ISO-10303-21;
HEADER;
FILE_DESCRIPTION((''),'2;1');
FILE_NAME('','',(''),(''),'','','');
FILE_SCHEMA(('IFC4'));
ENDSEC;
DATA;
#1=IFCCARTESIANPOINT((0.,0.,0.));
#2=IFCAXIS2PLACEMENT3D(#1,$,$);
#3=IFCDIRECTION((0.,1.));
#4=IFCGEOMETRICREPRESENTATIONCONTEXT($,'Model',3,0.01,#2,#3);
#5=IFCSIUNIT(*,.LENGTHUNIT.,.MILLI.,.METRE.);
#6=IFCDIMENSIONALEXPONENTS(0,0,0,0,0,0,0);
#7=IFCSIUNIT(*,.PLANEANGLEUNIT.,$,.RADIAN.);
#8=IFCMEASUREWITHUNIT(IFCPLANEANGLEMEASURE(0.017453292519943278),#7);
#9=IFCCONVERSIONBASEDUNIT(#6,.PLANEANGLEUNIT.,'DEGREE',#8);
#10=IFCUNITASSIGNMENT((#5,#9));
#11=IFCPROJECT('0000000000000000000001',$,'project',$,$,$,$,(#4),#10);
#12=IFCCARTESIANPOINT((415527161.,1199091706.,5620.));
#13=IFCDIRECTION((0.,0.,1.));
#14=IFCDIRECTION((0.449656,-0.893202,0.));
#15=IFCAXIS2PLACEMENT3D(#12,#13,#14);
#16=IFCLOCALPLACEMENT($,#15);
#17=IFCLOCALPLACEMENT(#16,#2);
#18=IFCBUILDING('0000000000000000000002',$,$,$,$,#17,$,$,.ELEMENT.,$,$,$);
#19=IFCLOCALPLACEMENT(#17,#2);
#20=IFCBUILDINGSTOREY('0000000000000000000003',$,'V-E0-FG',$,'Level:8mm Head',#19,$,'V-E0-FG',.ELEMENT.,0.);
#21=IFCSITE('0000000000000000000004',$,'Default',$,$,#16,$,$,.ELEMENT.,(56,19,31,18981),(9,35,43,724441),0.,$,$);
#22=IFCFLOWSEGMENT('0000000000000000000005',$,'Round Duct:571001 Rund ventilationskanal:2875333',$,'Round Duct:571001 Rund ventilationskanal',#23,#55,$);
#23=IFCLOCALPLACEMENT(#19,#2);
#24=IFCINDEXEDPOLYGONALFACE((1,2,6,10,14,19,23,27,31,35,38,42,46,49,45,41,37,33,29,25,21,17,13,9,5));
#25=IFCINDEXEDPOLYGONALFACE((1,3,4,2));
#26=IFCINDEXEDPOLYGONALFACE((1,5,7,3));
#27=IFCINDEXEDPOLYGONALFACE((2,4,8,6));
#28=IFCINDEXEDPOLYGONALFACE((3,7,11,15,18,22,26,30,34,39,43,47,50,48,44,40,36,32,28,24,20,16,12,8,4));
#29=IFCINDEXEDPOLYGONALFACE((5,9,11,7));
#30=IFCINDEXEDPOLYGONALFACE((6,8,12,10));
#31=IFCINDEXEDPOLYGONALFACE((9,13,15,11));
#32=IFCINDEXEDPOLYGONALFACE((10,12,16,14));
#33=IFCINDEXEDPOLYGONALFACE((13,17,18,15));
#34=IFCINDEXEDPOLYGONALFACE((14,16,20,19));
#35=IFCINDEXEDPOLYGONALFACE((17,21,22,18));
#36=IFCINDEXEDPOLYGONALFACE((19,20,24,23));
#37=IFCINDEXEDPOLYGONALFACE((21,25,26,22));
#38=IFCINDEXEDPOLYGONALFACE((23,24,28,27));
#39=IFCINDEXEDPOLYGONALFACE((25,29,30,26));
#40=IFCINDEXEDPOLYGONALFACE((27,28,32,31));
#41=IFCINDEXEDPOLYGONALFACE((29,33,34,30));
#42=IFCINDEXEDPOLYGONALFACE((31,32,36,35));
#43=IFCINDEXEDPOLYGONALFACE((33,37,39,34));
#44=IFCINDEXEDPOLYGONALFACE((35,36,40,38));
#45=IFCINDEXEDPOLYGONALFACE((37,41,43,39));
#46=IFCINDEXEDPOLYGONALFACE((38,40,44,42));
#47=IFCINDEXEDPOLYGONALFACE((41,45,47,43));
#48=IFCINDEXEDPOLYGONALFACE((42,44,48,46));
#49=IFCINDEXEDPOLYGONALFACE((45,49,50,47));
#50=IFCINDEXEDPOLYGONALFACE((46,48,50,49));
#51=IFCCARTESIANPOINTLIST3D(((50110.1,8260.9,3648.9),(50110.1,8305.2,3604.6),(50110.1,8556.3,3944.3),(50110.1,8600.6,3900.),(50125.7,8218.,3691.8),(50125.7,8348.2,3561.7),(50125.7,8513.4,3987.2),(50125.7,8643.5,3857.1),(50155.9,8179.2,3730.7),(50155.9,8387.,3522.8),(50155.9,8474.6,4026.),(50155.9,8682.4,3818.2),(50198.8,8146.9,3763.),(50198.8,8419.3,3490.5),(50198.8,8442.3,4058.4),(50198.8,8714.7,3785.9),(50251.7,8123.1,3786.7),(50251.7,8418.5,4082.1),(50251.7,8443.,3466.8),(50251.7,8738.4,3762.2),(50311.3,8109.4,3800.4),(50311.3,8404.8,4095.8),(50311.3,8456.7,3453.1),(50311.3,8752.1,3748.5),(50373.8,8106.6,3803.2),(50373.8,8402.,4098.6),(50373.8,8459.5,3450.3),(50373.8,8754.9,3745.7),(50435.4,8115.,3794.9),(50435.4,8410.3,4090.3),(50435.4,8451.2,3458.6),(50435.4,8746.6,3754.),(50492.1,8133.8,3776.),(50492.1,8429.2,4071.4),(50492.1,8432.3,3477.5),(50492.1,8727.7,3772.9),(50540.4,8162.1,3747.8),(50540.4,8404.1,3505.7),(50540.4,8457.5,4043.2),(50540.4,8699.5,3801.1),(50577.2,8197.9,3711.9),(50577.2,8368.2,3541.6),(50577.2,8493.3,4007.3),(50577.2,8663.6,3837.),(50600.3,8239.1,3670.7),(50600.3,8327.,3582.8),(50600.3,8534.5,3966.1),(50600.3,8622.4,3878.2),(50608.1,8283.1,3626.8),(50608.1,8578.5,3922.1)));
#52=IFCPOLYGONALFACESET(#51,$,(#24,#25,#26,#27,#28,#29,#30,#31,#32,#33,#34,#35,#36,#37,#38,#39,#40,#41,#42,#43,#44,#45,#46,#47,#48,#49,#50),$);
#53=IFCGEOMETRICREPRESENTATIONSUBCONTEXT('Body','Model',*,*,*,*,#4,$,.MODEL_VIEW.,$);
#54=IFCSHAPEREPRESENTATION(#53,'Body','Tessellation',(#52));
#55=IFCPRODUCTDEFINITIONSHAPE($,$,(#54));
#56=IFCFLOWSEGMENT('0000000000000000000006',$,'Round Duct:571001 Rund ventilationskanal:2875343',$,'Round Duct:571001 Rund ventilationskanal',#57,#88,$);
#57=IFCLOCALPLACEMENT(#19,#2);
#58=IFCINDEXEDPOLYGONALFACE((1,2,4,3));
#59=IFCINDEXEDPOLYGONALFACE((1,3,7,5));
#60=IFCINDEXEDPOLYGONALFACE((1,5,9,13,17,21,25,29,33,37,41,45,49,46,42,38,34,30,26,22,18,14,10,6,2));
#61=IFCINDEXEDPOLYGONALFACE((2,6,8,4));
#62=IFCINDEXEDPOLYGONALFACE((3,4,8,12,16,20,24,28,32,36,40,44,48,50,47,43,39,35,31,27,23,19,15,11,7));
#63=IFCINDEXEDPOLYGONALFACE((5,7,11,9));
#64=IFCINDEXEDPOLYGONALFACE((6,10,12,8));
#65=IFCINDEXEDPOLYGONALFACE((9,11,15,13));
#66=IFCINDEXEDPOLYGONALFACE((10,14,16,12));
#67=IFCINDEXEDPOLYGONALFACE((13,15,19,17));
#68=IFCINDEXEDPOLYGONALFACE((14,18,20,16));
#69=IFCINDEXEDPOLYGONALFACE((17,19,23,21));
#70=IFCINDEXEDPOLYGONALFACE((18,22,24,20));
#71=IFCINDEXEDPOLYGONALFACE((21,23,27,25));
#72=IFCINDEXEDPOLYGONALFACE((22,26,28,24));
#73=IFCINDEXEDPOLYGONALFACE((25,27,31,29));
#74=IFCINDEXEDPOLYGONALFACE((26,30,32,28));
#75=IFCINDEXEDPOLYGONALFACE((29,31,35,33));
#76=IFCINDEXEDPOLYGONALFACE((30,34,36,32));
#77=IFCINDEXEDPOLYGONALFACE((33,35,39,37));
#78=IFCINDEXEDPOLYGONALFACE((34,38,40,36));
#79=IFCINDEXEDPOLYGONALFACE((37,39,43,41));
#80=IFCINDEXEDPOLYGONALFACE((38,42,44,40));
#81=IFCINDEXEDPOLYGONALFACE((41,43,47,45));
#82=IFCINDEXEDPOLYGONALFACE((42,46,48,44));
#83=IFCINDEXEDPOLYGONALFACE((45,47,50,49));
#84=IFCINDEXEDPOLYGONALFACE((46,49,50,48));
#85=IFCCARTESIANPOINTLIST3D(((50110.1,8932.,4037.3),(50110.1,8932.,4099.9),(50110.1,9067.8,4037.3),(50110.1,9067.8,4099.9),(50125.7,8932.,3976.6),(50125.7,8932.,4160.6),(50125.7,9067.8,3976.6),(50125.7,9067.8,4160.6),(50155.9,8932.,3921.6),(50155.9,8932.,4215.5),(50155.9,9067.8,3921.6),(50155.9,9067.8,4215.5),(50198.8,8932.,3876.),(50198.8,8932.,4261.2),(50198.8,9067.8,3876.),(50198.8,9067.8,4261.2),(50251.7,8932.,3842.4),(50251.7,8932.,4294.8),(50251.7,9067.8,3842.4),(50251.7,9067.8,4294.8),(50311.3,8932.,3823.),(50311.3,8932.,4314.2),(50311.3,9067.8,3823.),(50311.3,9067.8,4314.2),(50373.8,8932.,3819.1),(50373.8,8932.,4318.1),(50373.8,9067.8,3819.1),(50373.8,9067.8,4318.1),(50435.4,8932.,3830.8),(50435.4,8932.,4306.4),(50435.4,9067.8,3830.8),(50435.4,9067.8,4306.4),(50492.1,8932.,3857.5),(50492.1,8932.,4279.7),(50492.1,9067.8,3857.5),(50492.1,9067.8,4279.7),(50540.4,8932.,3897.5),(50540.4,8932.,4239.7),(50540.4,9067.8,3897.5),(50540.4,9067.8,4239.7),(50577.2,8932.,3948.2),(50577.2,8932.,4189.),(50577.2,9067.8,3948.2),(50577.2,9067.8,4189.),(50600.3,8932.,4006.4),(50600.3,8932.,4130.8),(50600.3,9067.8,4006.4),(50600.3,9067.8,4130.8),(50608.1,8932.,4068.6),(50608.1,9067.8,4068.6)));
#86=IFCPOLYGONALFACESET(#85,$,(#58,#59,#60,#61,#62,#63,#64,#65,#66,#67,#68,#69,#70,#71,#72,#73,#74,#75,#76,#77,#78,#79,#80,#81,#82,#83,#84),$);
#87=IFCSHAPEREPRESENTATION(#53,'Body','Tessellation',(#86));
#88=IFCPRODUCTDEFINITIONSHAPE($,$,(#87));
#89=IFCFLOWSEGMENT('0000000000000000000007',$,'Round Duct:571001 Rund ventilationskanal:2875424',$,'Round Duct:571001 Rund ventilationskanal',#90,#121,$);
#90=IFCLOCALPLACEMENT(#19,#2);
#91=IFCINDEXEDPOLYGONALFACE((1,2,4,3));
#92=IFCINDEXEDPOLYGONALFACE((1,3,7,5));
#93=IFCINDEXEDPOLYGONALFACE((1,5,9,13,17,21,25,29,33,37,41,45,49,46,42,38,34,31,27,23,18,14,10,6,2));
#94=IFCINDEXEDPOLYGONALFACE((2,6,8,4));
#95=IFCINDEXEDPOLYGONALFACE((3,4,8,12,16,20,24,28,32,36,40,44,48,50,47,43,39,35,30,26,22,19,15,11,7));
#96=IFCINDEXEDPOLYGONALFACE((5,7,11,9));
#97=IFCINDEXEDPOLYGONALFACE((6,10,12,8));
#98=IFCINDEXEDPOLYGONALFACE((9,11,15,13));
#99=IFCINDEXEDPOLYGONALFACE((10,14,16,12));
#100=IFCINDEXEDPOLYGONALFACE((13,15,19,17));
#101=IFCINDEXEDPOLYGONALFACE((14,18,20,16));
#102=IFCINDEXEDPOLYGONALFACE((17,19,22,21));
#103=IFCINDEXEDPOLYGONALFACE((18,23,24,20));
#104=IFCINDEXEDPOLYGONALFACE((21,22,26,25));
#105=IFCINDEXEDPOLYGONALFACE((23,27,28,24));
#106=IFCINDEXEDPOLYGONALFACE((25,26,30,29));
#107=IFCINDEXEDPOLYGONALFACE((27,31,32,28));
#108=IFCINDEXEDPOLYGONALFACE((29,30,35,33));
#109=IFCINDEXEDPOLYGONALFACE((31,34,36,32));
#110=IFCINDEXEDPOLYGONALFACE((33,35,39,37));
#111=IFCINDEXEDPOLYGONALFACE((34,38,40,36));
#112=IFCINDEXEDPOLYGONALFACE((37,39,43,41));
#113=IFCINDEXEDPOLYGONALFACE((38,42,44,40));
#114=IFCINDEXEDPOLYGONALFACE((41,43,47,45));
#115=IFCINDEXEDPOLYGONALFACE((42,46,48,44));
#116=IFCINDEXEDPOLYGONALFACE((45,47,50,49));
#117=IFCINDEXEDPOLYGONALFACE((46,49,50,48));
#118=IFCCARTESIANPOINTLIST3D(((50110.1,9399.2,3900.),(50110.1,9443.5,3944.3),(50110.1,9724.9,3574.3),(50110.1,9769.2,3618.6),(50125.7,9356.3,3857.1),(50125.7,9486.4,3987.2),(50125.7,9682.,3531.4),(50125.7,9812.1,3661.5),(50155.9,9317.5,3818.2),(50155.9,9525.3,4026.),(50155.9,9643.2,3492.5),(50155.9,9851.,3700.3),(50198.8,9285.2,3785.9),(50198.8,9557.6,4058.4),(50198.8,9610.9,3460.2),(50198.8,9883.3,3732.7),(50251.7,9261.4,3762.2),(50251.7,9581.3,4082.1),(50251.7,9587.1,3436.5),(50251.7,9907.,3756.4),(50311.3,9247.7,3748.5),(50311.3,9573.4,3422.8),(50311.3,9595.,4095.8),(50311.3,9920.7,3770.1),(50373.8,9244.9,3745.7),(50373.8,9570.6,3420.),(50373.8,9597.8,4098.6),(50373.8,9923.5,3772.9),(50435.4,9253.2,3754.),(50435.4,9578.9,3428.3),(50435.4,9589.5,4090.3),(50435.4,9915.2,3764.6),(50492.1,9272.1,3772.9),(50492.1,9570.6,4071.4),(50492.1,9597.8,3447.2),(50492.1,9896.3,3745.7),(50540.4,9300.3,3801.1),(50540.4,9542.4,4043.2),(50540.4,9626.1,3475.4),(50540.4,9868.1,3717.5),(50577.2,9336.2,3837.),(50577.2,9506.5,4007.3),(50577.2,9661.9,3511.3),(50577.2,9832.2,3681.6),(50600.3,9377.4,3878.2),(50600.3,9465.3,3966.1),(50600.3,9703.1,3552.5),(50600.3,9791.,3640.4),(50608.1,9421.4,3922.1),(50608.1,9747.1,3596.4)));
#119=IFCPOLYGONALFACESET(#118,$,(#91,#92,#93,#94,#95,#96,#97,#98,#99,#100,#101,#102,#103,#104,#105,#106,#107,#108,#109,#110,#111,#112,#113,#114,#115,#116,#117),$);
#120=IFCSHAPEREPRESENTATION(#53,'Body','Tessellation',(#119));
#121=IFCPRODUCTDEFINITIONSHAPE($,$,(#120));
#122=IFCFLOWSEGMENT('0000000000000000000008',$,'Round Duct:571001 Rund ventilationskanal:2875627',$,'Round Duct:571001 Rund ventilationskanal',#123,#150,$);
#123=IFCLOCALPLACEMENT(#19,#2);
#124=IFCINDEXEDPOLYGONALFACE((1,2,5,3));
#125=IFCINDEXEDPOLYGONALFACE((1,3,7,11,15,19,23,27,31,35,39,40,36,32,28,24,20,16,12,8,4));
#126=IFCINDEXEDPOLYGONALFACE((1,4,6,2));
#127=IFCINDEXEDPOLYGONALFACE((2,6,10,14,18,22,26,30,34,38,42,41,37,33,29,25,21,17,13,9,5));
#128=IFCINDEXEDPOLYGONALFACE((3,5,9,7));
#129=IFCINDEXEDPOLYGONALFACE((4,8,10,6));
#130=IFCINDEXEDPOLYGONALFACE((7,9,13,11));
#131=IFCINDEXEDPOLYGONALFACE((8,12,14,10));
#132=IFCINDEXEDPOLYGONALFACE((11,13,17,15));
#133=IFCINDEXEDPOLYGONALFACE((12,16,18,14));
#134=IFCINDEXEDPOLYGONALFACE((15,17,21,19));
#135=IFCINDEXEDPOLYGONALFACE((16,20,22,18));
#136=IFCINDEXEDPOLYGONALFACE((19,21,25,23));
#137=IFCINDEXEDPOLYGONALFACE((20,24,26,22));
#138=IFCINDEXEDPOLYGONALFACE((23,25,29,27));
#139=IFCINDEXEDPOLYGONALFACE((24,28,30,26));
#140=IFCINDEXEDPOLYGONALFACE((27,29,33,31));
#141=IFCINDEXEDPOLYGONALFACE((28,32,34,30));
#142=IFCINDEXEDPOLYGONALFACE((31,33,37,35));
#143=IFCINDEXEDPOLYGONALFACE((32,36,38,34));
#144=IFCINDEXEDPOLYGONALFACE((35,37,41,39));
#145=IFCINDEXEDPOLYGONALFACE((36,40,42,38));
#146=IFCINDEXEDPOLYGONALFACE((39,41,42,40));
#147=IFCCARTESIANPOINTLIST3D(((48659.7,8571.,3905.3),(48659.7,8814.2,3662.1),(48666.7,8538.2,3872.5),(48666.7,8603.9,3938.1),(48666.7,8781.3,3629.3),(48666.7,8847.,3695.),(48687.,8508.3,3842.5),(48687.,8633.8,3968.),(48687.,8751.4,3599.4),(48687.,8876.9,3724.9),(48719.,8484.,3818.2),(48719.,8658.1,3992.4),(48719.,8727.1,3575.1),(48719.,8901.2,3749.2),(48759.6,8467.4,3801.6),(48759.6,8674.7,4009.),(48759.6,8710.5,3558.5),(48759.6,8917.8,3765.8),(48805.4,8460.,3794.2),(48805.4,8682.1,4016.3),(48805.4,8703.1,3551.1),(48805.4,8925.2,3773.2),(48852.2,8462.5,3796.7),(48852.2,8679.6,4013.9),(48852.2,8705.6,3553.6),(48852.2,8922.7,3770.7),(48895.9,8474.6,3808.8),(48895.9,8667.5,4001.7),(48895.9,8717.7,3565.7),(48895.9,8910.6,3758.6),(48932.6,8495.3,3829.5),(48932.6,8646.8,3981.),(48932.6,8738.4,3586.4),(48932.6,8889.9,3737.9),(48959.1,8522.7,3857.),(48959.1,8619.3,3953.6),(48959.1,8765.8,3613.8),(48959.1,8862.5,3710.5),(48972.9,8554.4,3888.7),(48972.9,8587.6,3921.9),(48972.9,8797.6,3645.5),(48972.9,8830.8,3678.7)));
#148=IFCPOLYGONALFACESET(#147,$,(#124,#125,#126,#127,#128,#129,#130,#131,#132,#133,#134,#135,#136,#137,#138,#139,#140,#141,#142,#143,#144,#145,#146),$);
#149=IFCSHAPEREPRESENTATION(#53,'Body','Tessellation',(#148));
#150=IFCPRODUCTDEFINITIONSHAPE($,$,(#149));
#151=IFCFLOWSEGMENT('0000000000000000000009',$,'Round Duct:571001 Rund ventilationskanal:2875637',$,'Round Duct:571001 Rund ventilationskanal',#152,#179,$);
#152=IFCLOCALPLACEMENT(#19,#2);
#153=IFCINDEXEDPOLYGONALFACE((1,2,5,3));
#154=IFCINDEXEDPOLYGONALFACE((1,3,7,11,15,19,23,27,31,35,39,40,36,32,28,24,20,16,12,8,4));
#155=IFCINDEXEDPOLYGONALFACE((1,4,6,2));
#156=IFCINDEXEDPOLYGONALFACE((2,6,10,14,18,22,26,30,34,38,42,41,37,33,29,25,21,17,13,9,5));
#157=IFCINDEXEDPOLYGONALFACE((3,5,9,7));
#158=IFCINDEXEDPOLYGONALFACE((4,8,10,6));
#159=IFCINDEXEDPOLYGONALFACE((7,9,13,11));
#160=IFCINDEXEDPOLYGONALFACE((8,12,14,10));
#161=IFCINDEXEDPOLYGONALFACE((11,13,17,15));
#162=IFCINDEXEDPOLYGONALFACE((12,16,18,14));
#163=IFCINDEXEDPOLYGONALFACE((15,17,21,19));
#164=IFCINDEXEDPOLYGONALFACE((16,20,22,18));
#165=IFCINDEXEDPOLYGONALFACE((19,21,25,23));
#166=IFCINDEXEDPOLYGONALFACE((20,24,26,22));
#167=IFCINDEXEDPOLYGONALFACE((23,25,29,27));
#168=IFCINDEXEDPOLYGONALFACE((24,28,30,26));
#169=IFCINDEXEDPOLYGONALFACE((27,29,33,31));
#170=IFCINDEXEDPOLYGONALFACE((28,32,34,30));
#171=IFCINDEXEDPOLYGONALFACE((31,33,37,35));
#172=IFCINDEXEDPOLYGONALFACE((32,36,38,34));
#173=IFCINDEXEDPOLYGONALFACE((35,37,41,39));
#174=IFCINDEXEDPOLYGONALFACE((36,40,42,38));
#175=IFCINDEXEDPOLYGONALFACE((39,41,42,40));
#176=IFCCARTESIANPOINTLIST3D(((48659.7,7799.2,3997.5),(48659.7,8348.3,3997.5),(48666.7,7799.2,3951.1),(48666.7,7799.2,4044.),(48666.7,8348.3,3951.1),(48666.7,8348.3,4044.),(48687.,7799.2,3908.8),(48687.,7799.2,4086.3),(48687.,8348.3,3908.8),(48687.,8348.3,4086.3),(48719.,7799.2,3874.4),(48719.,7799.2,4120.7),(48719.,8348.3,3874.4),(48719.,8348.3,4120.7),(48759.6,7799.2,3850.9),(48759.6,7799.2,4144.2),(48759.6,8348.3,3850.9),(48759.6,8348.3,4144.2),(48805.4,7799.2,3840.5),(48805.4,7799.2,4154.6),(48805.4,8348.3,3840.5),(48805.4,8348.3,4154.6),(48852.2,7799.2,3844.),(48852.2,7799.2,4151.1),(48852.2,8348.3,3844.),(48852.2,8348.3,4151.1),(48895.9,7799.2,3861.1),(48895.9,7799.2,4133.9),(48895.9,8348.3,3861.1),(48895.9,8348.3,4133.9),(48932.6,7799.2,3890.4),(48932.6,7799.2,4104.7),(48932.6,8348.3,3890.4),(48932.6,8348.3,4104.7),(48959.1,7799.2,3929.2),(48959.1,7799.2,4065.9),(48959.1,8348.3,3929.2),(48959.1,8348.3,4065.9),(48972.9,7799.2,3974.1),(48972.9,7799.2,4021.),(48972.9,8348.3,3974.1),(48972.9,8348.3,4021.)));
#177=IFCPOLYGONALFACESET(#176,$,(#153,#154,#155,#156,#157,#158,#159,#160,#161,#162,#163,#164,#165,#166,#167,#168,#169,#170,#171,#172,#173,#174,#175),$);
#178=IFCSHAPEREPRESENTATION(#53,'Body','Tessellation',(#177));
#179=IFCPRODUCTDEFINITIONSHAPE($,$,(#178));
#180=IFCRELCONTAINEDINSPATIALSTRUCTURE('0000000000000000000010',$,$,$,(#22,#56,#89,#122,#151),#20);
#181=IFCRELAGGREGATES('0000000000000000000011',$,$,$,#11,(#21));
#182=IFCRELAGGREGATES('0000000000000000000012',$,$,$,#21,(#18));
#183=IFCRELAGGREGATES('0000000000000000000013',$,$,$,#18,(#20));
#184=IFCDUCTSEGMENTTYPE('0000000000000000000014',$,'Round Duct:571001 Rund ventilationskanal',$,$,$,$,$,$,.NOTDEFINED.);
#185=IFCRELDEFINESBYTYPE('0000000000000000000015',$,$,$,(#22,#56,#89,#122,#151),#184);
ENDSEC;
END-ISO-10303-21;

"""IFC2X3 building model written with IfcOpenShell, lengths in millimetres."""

from ifc_helpers import new_model, entity, si_unit, converted_unit, direction, frame, frame_2d, origin, origin_2d_with_axis, place, context, subcontext, project, spatial, circle, extrude, type_object, element, save


model = new_model("IFC2X3")

# Units and contexts
model_context = context("Model", 3, precision=0.01, world=origin(), true_north=direction((0.0, 1.0)))
body_context = subcontext(model_context, "Body", "Model", "MODEL_VIEW")
ifc_project = project(units=[si_unit("LENGTHUNIT", "METRE", prefix="MILLI"), converted_unit("PLANEANGLEUNIT", "DEGREE", entity("IfcPlaneAngleMeasure", 0.017453292519943278), si_unit("PLANEANGLEUNIT", "RADIAN"), dimensions=[0, 0, 0, 0, 0, 0, 0])], contexts=[model_context])

# Site, building, storey
site_placement = place(None, frame((415527161.0, 1199091706.0, 5620.0), z_axis=(0.0, 0.0, 1.0), x_axis=(0.449656, -0.893202, 0.0)))
site = spatial("IfcSite", under=ifc_project, at=site_placement, Name="Default", CompositionType="ELEMENT", RefLatitude=(56, 19, 31, 18981), RefLongitude=(9, 35, 43, 724441), RefElevation=0.0)
building_placement = place(site_placement, origin())
building = spatial("IfcBuilding", under=site, at=building_placement, CompositionType="ELEMENT")
storey_placement = place(building_placement, origin())
storey = spatial("IfcBuildingStorey", under=building, at=storey_placement, Name="V-E0-FG", ObjectType="Level:8mm Head", LongName="V-E0-FG", CompositionType="ELEMENT", Elevation=0.0)

# Flow segments
duct_segment_type = type_object("IfcDuctSegmentType", Name="Round Duct:571001 Rund ventilationskanal", PredefinedType="NOTDEFINED")
flow_segment_1_placement = place(storey_placement, origin())
element("IfcFlowSegment", 1, at=flow_segment_1_placement, inside=storey, type_object=duct_segment_type, Name="Round Duct:571001 Rund ventilationskanal:2875333", ObjectType="Round Duct:571001 Rund ventilationskanal", context=body_context, shape_type="SweptSolid", body=[
    extrude(circle(Radius=250.0, at=frame_2d((0.0, 0.0), x_axis=(1.0, 0.0))), frame((50358.1, 8283.1, 3626.8), z_axis=(0.0, 0.707107, 0.707107), x_axis=(1.0, 0.0, 0.0)), (0.0, 0.0, 1.0), 417.7),
])
flow_segment_2_placement = place(storey_placement, origin())
element("IfcFlowSegment", 2, at=flow_segment_2_placement, inside=storey, type_object=duct_segment_type, Name="Round Duct:571001 Rund ventilationskanal:2875343", ObjectType="Round Duct:571001 Rund ventilationskanal", context=body_context, shape_type="SweptSolid", body=[
    extrude(circle(Radius=250.0, at=origin_2d_with_axis()), frame((50358.1, 8932.0, 4068.6), z_axis=(0.0, 1.0, 0.0), x_axis=(1.0, 0.0, 0.0)), (0.0, 0.0, 1.0), 135.8),
])
flow_segment_3_placement = place(storey_placement, origin())
element("IfcFlowSegment", 3, at=flow_segment_3_placement, inside=storey, type_object=duct_segment_type, Name="Round Duct:571001 Rund ventilationskanal:2875424", ObjectType="Round Duct:571001 Rund ventilationskanal", context=body_context, shape_type="SweptSolid", body=[
    extrude(circle(Radius=250.0, at=frame_2d((0.0, 0.0), x_axis=(1.0, 0.0))), frame((50358.1, 9421.4, 3922.1), z_axis=(0.0, 0.707107, -0.707106), x_axis=(1.0, 0.0, 0.0)), (0.0, 0.0, 1.0), 460.6),
])
flow_segment_4_placement = place(storey_placement, origin())
element("IfcFlowSegment", 4, at=flow_segment_4_placement, inside=storey, type_object=duct_segment_type, Name="Round Duct:571001 Rund ventilationskanal:2875627", ObjectType="Round Duct:571001 Rund ventilationskanal", context=body_context, shape_type="SweptSolid", body=[
    extrude(circle(Radius=157.5, at=origin_2d_with_axis()), frame((48817.2, 8571.0, 3905.3), z_axis=(0.0, 0.707107, -0.707107), x_axis=(-1.0, 0.0, 0.0)), (0.0, 0.0, 1.0), 343.9),
])
flow_segment_5_placement = place(storey_placement, origin())
element("IfcFlowSegment", 5, at=flow_segment_5_placement, inside=storey, type_object=duct_segment_type, Name="Round Duct:571001 Rund ventilationskanal:2875637", ObjectType="Round Duct:571001 Rund ventilationskanal", context=body_context, shape_type="SweptSolid", body=[
    extrude(circle(Radius=157.5, at=frame_2d((0.0, 0.0), x_axis=(1.0, 0.0))), frame((48817.2, 7799.2, 3997.5), z_axis=(0.0, 1.0, 0.0), x_axis=(-1.0, 0.0, 0.0)), (0.0, 0.0, 1.0), 549.1),
])

save(model, "model.ifc")
